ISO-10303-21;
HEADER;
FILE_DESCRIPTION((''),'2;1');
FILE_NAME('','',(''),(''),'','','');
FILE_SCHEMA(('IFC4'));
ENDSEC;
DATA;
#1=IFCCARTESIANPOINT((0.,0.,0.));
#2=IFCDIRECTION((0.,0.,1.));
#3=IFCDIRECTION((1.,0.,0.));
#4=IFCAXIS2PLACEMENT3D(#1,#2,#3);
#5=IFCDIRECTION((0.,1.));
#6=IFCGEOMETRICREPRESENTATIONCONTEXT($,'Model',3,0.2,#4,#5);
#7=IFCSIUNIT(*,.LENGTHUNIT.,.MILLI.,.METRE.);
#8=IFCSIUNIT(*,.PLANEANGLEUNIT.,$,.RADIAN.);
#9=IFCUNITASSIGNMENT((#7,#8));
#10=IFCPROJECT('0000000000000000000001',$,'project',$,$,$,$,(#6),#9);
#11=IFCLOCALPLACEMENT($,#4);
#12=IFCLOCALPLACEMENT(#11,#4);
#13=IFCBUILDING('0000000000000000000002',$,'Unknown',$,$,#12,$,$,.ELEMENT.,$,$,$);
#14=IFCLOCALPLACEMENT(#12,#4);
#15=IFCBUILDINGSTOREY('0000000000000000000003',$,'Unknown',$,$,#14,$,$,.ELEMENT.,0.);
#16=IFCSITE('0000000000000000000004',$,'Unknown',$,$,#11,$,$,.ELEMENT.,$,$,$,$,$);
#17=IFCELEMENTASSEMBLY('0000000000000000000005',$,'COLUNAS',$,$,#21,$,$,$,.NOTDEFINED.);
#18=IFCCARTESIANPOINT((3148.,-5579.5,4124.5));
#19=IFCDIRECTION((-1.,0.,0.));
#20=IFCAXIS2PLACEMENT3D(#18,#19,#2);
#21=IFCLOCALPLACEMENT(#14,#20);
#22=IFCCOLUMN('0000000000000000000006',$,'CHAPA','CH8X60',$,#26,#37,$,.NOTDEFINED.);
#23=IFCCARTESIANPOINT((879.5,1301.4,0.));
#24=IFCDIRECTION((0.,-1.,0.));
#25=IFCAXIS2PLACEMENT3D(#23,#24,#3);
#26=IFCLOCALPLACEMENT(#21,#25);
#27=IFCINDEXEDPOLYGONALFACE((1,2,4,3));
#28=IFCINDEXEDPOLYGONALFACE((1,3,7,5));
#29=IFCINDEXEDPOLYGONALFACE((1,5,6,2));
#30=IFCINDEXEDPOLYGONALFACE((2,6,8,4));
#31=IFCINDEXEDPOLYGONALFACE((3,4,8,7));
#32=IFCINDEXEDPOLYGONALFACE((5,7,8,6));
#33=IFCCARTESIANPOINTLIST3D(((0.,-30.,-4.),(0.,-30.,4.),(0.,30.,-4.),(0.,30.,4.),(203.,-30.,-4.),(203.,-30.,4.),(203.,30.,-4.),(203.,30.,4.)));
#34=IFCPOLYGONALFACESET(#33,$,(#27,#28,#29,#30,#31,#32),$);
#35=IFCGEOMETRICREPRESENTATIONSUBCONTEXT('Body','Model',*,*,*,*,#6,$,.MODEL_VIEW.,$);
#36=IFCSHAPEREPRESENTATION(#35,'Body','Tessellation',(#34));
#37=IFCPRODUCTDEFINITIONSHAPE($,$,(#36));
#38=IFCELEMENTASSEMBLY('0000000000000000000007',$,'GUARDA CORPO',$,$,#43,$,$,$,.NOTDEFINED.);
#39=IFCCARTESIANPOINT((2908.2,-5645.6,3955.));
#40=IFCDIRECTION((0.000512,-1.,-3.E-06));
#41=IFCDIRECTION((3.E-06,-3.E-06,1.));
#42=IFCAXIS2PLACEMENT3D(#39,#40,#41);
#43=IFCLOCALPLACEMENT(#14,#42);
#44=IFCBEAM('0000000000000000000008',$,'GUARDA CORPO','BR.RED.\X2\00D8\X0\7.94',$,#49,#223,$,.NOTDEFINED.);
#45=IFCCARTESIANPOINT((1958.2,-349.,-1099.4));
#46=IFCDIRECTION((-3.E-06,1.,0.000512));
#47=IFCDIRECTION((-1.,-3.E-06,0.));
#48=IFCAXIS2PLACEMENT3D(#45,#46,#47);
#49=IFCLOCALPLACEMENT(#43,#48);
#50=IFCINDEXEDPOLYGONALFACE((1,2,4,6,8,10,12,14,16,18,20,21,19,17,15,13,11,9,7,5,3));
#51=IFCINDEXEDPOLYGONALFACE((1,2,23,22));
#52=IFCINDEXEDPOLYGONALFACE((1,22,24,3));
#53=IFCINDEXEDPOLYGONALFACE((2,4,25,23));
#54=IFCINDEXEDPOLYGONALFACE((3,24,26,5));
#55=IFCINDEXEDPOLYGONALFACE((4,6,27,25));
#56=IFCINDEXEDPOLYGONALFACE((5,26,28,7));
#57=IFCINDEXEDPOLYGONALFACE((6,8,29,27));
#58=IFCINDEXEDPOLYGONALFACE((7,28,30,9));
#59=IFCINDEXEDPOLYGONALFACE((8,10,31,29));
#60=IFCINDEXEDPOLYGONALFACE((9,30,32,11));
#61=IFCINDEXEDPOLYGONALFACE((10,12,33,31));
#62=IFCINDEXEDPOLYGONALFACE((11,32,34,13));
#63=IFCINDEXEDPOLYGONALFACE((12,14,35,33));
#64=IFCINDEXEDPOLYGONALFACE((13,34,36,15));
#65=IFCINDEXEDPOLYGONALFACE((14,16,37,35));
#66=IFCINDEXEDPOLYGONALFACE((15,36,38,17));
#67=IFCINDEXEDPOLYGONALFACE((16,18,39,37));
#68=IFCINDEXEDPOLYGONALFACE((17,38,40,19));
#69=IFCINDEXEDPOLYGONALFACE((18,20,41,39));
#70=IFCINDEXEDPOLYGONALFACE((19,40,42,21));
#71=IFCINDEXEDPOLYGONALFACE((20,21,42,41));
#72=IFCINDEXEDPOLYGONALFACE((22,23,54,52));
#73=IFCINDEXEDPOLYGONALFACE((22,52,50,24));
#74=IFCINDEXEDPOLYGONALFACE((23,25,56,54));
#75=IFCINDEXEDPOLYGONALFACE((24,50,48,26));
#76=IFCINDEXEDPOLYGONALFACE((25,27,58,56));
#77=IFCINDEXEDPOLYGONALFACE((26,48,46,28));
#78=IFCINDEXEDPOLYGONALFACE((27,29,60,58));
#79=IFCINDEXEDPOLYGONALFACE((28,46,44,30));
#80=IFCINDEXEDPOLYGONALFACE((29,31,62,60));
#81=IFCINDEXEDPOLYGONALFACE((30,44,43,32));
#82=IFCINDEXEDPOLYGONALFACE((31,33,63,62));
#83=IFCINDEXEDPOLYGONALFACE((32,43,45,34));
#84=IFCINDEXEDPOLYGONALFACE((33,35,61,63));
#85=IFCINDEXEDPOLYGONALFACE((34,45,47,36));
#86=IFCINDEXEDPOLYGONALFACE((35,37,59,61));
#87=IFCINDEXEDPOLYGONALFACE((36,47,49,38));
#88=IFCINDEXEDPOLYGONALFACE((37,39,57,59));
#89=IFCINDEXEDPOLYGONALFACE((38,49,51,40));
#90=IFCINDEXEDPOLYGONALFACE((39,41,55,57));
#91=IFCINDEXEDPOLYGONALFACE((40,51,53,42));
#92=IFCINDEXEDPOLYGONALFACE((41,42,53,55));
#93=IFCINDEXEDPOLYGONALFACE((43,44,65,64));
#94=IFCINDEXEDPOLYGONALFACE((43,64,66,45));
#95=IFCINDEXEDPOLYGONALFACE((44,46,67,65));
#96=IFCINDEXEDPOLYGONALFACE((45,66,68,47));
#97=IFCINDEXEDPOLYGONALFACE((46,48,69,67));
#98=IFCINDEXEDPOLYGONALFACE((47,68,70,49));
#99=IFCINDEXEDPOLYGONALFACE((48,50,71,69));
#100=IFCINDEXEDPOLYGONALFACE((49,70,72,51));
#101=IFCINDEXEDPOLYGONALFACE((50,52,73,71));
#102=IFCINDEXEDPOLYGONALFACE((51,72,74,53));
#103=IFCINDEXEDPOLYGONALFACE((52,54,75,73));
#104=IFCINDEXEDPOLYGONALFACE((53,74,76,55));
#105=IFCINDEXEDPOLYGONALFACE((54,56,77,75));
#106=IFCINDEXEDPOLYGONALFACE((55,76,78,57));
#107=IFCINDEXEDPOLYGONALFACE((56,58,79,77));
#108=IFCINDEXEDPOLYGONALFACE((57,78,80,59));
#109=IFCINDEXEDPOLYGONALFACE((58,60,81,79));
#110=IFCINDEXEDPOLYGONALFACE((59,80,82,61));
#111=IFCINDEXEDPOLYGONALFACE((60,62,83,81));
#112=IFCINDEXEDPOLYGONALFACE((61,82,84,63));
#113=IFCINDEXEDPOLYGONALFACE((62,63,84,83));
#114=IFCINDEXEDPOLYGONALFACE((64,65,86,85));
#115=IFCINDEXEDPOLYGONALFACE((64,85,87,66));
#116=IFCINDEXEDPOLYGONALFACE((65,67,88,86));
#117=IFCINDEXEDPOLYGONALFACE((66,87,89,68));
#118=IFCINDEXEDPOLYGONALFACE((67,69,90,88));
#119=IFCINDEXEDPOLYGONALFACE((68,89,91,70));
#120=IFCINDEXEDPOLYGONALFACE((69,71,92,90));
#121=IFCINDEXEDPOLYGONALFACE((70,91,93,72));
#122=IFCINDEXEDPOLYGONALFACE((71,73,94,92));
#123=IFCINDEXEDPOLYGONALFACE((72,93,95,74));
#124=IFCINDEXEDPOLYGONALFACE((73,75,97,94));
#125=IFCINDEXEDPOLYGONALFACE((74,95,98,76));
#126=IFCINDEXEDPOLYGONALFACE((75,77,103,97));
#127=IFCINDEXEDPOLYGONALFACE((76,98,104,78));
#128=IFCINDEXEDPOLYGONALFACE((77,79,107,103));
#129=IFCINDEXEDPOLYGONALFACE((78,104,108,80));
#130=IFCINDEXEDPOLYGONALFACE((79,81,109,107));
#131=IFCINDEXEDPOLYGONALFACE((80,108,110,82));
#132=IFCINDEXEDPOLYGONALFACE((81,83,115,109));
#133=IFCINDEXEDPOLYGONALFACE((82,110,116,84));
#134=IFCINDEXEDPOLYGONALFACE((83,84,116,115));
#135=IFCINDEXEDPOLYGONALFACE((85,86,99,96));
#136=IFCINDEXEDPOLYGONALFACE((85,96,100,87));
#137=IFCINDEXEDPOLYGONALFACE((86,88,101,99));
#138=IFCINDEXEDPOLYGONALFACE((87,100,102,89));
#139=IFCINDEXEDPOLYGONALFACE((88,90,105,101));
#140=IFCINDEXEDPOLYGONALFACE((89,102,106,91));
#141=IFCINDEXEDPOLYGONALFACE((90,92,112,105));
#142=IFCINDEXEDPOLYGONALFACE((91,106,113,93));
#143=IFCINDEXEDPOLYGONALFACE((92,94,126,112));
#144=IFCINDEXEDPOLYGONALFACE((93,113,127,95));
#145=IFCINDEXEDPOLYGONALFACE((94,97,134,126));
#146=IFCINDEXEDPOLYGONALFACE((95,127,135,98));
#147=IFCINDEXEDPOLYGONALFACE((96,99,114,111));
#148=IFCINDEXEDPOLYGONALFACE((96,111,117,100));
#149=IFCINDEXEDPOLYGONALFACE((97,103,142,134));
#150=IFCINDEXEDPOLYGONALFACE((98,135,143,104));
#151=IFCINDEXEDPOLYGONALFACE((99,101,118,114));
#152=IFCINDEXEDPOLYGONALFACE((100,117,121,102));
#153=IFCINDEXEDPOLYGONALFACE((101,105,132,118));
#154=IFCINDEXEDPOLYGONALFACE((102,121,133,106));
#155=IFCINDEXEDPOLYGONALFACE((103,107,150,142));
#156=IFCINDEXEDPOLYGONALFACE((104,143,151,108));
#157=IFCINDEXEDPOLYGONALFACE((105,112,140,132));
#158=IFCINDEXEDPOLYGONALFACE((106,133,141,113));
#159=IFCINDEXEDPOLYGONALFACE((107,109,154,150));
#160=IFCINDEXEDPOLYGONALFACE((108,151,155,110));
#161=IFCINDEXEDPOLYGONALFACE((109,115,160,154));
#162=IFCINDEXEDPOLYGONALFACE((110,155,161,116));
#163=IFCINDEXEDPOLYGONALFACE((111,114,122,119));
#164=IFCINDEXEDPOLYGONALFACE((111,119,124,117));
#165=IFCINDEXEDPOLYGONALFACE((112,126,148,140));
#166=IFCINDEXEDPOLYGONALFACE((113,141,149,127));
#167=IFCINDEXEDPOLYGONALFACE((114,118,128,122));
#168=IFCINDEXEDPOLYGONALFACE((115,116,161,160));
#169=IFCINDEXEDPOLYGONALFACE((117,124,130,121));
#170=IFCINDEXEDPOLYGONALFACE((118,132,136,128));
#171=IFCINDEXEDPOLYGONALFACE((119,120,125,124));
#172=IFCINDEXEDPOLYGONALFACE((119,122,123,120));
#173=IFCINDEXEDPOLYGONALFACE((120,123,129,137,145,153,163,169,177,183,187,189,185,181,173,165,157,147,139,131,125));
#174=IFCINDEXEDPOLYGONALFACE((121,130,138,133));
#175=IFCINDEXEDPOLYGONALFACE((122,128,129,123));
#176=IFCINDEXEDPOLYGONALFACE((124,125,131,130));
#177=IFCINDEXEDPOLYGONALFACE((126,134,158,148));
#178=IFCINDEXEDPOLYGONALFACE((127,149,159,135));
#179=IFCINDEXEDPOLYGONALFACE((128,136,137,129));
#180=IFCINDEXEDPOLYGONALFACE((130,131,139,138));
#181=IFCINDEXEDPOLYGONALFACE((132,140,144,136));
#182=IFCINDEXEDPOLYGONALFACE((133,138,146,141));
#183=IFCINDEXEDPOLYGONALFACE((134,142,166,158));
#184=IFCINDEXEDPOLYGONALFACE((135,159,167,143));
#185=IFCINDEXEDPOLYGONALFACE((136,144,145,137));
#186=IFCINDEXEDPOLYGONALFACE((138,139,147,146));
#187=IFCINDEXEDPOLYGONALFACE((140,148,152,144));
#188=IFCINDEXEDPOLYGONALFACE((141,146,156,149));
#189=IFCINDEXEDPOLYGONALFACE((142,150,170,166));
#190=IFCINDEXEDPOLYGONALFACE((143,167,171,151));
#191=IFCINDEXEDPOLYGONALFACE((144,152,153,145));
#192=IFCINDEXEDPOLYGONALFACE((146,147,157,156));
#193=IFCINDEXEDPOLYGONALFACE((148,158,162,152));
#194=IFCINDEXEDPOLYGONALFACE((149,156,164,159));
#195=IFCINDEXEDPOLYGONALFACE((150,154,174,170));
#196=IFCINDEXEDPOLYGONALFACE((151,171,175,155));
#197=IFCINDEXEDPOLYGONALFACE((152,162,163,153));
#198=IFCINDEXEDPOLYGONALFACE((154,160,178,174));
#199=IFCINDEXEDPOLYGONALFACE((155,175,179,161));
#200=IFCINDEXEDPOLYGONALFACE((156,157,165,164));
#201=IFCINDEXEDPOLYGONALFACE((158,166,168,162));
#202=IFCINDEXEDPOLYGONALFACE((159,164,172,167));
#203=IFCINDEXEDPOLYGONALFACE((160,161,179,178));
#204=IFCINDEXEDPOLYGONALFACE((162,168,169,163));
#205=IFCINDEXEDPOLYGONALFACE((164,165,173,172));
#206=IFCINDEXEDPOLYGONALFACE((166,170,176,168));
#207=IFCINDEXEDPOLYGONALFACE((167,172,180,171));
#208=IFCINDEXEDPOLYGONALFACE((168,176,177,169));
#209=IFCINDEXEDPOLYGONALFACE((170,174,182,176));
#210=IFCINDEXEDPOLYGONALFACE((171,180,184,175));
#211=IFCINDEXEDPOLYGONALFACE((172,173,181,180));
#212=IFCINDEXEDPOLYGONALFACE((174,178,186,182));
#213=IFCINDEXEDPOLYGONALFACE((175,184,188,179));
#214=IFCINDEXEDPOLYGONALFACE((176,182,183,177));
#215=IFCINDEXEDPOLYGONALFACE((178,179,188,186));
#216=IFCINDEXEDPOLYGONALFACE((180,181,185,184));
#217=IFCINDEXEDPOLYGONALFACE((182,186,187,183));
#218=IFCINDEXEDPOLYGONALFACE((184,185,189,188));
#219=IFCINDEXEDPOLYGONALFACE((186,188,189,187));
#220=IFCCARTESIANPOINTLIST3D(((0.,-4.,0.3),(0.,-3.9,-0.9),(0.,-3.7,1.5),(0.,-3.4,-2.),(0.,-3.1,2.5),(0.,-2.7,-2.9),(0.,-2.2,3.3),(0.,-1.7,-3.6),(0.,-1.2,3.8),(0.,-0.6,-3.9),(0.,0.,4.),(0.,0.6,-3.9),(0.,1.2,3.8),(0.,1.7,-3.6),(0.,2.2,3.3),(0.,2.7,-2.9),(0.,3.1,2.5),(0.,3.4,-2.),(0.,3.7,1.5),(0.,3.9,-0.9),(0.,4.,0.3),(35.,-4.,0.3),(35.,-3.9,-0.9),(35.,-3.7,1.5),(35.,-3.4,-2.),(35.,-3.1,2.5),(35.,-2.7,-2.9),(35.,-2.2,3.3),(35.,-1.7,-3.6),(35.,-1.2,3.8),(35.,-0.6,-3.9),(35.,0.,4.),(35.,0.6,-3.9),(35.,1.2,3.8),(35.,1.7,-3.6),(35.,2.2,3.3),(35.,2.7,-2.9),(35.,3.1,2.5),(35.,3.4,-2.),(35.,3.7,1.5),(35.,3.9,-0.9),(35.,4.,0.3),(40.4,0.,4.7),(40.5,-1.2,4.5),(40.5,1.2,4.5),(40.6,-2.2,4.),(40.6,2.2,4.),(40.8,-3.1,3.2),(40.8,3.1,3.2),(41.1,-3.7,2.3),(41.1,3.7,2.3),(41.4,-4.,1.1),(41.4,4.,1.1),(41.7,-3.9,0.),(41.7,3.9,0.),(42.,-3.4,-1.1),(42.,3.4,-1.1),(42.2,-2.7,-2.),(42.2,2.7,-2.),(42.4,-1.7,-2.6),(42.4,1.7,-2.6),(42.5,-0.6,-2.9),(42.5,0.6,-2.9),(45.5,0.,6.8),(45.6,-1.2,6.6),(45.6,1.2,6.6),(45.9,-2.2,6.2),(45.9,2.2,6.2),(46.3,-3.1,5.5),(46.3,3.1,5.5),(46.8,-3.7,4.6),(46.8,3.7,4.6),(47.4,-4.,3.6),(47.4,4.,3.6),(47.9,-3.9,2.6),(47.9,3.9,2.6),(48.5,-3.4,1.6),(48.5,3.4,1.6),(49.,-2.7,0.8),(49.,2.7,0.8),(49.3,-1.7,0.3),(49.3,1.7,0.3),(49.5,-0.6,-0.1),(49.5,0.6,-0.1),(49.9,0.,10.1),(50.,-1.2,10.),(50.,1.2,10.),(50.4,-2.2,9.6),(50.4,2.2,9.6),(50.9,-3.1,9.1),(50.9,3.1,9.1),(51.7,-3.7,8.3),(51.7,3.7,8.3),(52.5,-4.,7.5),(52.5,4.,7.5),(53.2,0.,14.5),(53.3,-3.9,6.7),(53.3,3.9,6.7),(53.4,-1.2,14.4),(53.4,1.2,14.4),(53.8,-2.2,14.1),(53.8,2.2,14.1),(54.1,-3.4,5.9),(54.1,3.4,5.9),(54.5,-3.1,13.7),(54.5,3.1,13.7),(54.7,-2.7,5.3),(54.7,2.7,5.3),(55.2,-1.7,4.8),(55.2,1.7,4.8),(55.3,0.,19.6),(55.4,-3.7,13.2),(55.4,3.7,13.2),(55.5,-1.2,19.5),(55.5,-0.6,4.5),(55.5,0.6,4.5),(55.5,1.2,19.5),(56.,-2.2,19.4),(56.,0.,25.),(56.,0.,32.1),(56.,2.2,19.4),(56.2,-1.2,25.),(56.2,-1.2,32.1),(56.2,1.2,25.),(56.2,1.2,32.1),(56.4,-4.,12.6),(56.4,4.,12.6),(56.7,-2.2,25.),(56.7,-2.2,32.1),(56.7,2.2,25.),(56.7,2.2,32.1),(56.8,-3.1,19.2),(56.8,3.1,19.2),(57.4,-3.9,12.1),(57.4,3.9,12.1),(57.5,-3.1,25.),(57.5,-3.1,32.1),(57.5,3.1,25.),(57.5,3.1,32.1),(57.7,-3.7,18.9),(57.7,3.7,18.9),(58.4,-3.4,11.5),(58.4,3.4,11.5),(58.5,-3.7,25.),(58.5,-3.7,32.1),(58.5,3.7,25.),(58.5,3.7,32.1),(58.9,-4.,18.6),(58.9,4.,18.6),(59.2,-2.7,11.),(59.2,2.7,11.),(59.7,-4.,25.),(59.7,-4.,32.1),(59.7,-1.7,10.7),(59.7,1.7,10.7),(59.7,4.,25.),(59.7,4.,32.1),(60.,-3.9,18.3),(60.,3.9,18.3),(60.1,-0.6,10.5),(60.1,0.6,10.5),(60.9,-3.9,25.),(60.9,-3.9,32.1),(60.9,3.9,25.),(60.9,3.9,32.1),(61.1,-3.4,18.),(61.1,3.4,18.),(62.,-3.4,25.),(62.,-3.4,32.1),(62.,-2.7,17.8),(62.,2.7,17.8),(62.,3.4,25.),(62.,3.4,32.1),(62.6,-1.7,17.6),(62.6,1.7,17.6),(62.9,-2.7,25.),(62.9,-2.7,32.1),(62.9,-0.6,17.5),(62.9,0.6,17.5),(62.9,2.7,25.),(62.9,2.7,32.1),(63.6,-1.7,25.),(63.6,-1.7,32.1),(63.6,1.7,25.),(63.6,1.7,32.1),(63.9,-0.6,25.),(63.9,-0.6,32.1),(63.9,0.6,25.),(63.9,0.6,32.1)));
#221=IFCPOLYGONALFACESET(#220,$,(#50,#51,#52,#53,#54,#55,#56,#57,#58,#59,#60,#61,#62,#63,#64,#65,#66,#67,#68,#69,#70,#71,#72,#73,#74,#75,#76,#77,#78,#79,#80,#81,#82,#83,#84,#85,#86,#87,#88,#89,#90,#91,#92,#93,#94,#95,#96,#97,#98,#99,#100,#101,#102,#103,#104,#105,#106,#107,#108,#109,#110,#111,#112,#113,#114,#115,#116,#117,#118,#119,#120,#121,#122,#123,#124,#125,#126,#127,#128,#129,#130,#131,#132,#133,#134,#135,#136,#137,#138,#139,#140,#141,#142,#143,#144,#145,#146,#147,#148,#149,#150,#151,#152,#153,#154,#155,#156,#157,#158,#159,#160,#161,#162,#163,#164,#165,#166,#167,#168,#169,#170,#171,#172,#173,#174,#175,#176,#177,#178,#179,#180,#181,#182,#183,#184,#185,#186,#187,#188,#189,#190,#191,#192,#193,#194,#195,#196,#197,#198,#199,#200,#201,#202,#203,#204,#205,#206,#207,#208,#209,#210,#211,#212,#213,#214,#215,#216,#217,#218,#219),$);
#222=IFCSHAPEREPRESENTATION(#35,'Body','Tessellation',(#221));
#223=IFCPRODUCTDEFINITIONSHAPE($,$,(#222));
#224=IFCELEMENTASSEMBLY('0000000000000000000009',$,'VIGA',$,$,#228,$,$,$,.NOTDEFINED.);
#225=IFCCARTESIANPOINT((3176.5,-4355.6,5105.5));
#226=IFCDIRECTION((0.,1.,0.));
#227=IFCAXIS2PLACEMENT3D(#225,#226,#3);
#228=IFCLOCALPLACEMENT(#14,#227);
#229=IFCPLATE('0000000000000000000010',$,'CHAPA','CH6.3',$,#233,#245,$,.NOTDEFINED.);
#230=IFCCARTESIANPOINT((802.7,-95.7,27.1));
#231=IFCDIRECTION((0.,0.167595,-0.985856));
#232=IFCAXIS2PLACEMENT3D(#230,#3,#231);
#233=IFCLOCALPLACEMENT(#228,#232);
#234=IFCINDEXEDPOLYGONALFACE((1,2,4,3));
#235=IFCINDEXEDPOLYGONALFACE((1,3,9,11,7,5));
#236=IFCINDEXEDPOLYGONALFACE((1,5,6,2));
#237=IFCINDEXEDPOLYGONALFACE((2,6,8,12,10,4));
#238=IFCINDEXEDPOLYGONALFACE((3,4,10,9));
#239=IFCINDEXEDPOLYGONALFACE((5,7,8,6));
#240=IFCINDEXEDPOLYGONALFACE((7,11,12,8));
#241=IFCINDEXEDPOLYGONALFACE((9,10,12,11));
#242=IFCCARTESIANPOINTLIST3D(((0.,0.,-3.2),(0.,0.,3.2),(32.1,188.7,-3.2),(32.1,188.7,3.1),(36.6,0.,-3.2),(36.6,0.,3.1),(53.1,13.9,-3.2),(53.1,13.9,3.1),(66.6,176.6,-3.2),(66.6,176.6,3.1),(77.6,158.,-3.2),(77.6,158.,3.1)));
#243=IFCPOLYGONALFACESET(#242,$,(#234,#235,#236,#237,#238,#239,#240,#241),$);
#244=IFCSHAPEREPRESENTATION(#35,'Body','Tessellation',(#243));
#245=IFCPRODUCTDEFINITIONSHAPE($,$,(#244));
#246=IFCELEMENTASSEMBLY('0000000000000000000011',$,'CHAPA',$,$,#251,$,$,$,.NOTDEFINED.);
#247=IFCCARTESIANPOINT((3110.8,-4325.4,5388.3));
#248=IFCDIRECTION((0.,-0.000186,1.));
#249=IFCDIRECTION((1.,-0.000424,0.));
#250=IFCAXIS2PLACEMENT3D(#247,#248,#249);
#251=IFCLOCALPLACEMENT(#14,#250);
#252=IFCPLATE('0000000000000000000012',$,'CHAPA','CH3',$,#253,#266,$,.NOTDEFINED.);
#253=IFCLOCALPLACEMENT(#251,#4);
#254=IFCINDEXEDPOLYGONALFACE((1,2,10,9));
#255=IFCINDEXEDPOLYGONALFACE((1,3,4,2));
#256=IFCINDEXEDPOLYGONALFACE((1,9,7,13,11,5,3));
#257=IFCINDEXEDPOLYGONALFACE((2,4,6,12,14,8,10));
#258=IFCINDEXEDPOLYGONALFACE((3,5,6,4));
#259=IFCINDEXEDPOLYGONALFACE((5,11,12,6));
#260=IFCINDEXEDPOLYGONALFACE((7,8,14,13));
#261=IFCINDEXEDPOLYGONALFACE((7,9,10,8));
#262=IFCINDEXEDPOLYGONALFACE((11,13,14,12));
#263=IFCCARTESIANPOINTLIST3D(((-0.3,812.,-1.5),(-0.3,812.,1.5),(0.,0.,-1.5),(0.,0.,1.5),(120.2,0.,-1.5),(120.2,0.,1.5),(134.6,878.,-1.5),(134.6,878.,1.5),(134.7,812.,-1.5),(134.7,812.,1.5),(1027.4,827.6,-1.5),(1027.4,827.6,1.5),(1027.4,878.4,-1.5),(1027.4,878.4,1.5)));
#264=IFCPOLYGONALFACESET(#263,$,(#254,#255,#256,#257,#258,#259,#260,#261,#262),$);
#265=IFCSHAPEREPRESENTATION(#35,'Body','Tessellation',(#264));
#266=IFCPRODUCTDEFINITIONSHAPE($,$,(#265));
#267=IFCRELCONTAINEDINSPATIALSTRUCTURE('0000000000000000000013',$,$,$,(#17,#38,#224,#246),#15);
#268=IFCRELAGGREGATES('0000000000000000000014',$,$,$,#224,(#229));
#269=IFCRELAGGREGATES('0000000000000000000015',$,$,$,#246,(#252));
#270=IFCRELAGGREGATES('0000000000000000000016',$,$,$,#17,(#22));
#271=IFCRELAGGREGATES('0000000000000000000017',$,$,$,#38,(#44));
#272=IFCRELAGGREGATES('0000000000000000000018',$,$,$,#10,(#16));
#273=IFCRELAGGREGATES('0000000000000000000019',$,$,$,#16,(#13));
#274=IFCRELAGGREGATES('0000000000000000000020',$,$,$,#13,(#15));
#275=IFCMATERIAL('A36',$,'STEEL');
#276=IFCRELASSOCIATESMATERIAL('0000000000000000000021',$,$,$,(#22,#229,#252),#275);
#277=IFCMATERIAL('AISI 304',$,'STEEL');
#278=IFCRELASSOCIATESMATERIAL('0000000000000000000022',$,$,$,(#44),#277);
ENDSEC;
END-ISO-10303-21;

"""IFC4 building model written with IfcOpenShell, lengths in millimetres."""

from ifc_helpers import new_model, entity, si_unit, direction, frame, origin_with_axes, place, context, subcontext, project, spatial, line, indexed_curve, outline, extrude, material, element, aggregate, save


model = new_model("IFC4")

# Units and contexts
model_context = context("Model", 3, precision=0.2, world=origin_with_axes(), true_north=direction((0.0, 1.0)))
body_context = subcontext(model_context, "Body", "Model", "MODEL_VIEW")
ifc_project = project(units=[si_unit("LENGTHUNIT", "METRE", prefix="MILLI"), si_unit("PLANEANGLEUNIT", "RADIAN")], contexts=[model_context])

# Site, building, storey
site_placement = place(None, origin_with_axes())
site = spatial("IfcSite", under=ifc_project, at=site_placement, Name="Unknown", CompositionType="ELEMENT")
building_placement = place(site_placement, origin_with_axes())
building = spatial("IfcBuilding", under=site, at=building_placement, Name="Unknown", CompositionType="ELEMENT")
storey_placement = place(building_placement, origin_with_axes())
storey = spatial("IfcBuildingStorey", under=building, at=storey_placement, Name="Unknown", CompositionType="ELEMENT", Elevation=0.0)

# Element assembly, column
assembly_1_placement = place(storey_placement, frame((3148.0, -5579.5, 4124.5), z_axis=(-1.0, 0.0, 0.0), x_axis=(0.0, 0.0, 1.0)))
assembly_1 = element("IfcElementAssembly", 1, at=assembly_1_placement, inside=storey, Name="COLUNAS", PredefinedType="NOTDEFINED")
ifc_material_1 = material(Name="A36", Category="STEEL")
column_placement = place(assembly_1_placement, frame((879.5, 1301.4, 0.0), z_axis=(0.0, -1.0, 0.0), x_axis=(1.0, 0.0, 0.0)))
column = element("IfcColumn", 2, at=column_placement, material=ifc_material_1, Name="CHAPA", Description="CH8X60", PredefinedType="NOTDEFINED", context=body_context, shape_type="SolidModel", body=[
    extrude(outline(indexed_curve([(-4.0, -30.0), (4.0, -30.0), (4.0, 30.0), (-4.0, 30.0)], segments=[line(1, 2, 3, 4, 1)])), frame((0.0, 0.0, 0.0), z_axis=(-1.0, 0.0, 0.0), x_axis=(0.0, 0.0, 1.0)), (0.0, 0.0, -1.0), 203.0),
])

# Element assembly, beam
assembly_2_placement = place(storey_placement, frame((2908.2, -5645.6, 3955.0), z_axis=(0.000512, -1.0, -0.000003), x_axis=(0.000003, -0.000003, 1.0)))
assembly_2 = element("IfcElementAssembly", 3, at=assembly_2_placement, inside=storey, Name="GUARDA CORPO", PredefinedType="NOTDEFINED")
ifc_material_2 = material(Name="AISI 304", Category="STEEL")
beam_1_placement = place(assembly_2_placement, frame((1958.2, -349.0, -1099.4), z_axis=(-0.000003, 1.0, 0.000512), x_axis=(-1.0, -0.000003, 0.0)))
beam_1 = element("IfcBeam", 4, at=beam_1_placement, material=ifc_material_2, Name="GUARDA CORPO", Description="BR.RED.Ø7.94", PredefinedType="NOTDEFINED", context=body_context, shape_type="SolidModel", body=[
    entity("IfcSweptDiskSolid", entity("IfcIndexedPolyCurve", entity("IfcCartesianPointList3D", [[0.0, 0.0, 0.0], [35.0, 0.0, 0.0], [52.7, 0.0, 7.3], [60.0, 0.0, 25.0], [60.0, 0.0, 32.1]]), [entity("IfcLineIndex", [1, 2]), entity("IfcArcIndex", [2, 3, 4]), entity("IfcLineIndex", [4, 5])]), 4.0),
])

# Element assemblies, plates
assembly_3_placement = place(storey_placement, frame((3176.5, -4355.6, 5105.5), z_axis=(0.0, 1.0, 0.0), x_axis=(1.0, 0.0, 0.0)))
assembly_3 = element("IfcElementAssembly", 5, at=assembly_3_placement, inside=storey, Name="VIGA", PredefinedType="NOTDEFINED")
plate_1_placement = place(assembly_3_placement, frame((802.7, -95.7, 27.1), z_axis=(1.0, 0.0, 0.0), x_axis=(0.0, 0.167595, -0.985856)))
plate_1 = element("IfcPlate", 6, at=plate_1_placement, material=ifc_material_1, Name="CHAPA", Description="CH6.3", PredefinedType="NOTDEFINED", context=body_context, shape_type="SolidModel", body=[
    extrude(outline(indexed_curve([(0.0, 0.0), (36.6, 0.0), (53.1, 13.9), (77.6, 158.0), (66.6, 176.6), (32.1, 188.7)], segments=[line(1, 2, 3, 4, 5, 6, 1)])), frame((0.0, 0.0, 3.1), z_axis=(0.0, 0.0, 1.0), x_axis=(1.0, 0.0, 0.0)), (0.0, 0.0, -1.0), 6.3),
])
aggregate(assembly_3, [plate_1])
assembly_4_placement = place(storey_placement, frame((3110.8, -4325.4, 5388.3), z_axis=(0.0, -0.000186, 1.0), x_axis=(1.0, -0.000424, 0.0)))
assembly_4 = element("IfcElementAssembly", 7, at=assembly_4_placement, inside=storey, Name="CHAPA", PredefinedType="NOTDEFINED")
plate_2_placement = place(assembly_4_placement, origin_with_axes())
plate_2 = element("IfcPlate", 8, at=plate_2_placement, material=ifc_material_1, Name="CHAPA", Description="CH3", PredefinedType="NOTDEFINED", context=body_context, shape_type="SolidModel", body=[
    extrude(outline(indexed_curve([(0.0, 0.0), (120.2, 0.0), (1027.4, 827.6), (1027.4, 878.4), (134.6, 878.0), (134.7, 812.0), (-0.3, 812.0)], segments=[line(1, 2, 3, 4, 5, 6, 7, 1)])), frame((0.0, 0.0, 1.5), z_axis=(0.0, 0.0, 1.0), x_axis=(1.0, 0.0, 0.0)), (0.0, 0.0, -1.0), 3.0),
])
aggregate(assembly_4, [plate_2])

aggregate(assembly_1, [column])

aggregate(assembly_2, [beam_1])

save(model, "model.ifc")
